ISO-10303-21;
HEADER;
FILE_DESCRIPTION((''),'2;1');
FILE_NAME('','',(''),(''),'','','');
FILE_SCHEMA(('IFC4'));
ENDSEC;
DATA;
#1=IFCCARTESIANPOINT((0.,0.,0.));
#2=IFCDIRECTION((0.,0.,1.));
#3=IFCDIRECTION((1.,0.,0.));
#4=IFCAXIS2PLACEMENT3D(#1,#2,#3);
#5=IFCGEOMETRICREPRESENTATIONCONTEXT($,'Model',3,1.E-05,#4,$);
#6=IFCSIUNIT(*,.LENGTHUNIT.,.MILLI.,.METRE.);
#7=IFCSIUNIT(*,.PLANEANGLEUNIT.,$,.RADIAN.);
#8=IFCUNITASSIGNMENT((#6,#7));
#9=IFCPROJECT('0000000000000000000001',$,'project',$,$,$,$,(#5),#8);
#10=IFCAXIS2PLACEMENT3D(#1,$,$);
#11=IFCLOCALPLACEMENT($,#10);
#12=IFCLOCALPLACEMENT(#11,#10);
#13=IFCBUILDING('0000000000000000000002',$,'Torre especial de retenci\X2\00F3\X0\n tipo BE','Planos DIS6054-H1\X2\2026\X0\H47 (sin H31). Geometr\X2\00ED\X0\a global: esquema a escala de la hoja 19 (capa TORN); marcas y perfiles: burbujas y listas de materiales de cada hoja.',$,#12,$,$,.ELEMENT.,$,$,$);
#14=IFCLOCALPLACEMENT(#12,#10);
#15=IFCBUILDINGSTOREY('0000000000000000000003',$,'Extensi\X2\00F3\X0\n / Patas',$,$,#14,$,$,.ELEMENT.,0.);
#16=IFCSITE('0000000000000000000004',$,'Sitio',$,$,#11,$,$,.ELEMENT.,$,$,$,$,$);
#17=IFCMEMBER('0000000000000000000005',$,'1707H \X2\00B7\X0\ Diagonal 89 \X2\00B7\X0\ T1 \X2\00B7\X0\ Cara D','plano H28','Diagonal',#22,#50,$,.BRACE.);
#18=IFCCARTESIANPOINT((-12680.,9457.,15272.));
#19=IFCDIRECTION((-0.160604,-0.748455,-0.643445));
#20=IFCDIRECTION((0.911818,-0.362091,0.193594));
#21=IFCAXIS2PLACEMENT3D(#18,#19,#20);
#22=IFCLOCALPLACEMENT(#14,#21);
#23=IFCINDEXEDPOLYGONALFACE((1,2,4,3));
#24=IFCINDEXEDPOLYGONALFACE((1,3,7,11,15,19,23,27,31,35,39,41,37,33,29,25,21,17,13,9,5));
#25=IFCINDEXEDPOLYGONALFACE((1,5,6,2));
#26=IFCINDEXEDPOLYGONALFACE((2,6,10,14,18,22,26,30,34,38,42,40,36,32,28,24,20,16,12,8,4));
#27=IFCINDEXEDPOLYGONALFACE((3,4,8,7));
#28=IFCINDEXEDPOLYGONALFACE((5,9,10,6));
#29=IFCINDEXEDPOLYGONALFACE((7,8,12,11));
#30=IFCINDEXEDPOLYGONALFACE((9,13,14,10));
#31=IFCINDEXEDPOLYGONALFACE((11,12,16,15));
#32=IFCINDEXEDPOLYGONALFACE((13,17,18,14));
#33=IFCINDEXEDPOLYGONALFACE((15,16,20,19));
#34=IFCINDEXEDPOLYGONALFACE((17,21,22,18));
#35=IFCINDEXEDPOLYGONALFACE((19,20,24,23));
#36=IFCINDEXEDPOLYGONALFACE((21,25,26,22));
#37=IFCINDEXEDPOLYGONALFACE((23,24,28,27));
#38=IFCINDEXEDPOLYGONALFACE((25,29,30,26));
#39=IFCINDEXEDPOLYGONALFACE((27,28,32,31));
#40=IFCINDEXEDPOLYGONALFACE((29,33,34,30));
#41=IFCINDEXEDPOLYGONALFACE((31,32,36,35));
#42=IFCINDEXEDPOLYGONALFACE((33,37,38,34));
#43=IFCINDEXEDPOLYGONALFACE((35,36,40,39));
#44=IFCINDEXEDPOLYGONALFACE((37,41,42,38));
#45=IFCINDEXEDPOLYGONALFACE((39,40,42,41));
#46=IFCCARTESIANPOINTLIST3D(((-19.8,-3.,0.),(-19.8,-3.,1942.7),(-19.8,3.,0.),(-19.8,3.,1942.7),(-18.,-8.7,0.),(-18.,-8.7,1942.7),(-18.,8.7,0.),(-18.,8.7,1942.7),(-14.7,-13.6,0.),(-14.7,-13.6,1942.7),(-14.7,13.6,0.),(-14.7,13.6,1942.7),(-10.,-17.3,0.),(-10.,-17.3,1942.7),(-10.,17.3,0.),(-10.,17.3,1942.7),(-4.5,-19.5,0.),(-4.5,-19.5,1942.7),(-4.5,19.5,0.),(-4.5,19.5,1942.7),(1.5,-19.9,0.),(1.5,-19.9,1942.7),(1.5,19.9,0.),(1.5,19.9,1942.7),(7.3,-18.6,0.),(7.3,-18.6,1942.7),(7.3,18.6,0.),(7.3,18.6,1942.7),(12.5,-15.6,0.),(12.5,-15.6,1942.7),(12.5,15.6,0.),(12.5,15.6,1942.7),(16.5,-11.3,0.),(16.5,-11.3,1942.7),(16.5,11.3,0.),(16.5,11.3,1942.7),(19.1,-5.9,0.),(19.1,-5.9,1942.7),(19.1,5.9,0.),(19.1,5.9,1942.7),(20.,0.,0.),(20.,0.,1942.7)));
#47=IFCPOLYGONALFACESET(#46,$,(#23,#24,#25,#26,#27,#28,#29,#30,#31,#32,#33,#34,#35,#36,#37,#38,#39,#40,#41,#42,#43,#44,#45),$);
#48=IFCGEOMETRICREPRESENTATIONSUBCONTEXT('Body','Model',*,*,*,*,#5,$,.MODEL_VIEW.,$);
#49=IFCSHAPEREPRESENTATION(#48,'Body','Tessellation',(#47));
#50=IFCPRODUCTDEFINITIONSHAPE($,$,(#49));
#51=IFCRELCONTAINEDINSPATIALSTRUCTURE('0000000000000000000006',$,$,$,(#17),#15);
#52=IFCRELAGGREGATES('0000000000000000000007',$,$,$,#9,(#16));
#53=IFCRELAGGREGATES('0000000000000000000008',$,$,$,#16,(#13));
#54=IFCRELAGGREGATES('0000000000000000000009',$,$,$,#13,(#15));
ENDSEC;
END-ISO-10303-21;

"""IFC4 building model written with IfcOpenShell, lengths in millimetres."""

from ifc_helpers import new_model, si_unit, frame, origin, origin_with_axes, place, context, subcontext, project, spatial, circle, extrude, element, save


model = new_model("IFC4")

# Units and contexts
model_context = context("Model", 3, precision=1e-05, world=origin_with_axes())
body_context = subcontext(model_context, "Body", "Model", "MODEL_VIEW")
ifc_project = project(units=[si_unit("LENGTHUNIT", "METRE", prefix="MILLI"), si_unit("PLANEANGLEUNIT", "RADIAN")], contexts=[model_context])

# Site, building, storey
site_placement = place(None, origin())
site = spatial("IfcSite", under=ifc_project, at=site_placement, Name="Sitio", CompositionType="ELEMENT")
building_placement = place(site_placement, origin())
building = spatial("IfcBuilding", under=site, at=building_placement, Name="Torre especial de retención tipo BE", Description="Planos DIS6054-H1…H47 (sin H31). Geometría global: esquema a escala de la hoja 19 (capa TORN); marcas y perfiles: burbujas y listas de materiales de cada hoja.", CompositionType="ELEMENT")
storey_placement = place(building_placement, origin())
storey = spatial("IfcBuildingStorey", under=building, at=storey_placement, Name="Extensión / Patas", CompositionType="ELEMENT", Elevation=0.0)

# Member
member_1_placement = place(storey_placement, frame((-12680.0, 9457.0, 15272.0), z_axis=(-0.160604, -0.748455, -0.643445), x_axis=(0.911818, -0.362091, 0.193594)))
element("IfcMember", 1, at=member_1_placement, inside=storey, Name="1707H · Diagonal 89 · T1 · Cara D", Description="plano H28", ObjectType="Diagonal", PredefinedType="BRACE", context=body_context, shape_type="SweptSolid", body=[
    extrude(circle(Radius=20.0), None, (0.0, 0.0, 1.0), 1942.7),
])

save(model, "model.ifc")
